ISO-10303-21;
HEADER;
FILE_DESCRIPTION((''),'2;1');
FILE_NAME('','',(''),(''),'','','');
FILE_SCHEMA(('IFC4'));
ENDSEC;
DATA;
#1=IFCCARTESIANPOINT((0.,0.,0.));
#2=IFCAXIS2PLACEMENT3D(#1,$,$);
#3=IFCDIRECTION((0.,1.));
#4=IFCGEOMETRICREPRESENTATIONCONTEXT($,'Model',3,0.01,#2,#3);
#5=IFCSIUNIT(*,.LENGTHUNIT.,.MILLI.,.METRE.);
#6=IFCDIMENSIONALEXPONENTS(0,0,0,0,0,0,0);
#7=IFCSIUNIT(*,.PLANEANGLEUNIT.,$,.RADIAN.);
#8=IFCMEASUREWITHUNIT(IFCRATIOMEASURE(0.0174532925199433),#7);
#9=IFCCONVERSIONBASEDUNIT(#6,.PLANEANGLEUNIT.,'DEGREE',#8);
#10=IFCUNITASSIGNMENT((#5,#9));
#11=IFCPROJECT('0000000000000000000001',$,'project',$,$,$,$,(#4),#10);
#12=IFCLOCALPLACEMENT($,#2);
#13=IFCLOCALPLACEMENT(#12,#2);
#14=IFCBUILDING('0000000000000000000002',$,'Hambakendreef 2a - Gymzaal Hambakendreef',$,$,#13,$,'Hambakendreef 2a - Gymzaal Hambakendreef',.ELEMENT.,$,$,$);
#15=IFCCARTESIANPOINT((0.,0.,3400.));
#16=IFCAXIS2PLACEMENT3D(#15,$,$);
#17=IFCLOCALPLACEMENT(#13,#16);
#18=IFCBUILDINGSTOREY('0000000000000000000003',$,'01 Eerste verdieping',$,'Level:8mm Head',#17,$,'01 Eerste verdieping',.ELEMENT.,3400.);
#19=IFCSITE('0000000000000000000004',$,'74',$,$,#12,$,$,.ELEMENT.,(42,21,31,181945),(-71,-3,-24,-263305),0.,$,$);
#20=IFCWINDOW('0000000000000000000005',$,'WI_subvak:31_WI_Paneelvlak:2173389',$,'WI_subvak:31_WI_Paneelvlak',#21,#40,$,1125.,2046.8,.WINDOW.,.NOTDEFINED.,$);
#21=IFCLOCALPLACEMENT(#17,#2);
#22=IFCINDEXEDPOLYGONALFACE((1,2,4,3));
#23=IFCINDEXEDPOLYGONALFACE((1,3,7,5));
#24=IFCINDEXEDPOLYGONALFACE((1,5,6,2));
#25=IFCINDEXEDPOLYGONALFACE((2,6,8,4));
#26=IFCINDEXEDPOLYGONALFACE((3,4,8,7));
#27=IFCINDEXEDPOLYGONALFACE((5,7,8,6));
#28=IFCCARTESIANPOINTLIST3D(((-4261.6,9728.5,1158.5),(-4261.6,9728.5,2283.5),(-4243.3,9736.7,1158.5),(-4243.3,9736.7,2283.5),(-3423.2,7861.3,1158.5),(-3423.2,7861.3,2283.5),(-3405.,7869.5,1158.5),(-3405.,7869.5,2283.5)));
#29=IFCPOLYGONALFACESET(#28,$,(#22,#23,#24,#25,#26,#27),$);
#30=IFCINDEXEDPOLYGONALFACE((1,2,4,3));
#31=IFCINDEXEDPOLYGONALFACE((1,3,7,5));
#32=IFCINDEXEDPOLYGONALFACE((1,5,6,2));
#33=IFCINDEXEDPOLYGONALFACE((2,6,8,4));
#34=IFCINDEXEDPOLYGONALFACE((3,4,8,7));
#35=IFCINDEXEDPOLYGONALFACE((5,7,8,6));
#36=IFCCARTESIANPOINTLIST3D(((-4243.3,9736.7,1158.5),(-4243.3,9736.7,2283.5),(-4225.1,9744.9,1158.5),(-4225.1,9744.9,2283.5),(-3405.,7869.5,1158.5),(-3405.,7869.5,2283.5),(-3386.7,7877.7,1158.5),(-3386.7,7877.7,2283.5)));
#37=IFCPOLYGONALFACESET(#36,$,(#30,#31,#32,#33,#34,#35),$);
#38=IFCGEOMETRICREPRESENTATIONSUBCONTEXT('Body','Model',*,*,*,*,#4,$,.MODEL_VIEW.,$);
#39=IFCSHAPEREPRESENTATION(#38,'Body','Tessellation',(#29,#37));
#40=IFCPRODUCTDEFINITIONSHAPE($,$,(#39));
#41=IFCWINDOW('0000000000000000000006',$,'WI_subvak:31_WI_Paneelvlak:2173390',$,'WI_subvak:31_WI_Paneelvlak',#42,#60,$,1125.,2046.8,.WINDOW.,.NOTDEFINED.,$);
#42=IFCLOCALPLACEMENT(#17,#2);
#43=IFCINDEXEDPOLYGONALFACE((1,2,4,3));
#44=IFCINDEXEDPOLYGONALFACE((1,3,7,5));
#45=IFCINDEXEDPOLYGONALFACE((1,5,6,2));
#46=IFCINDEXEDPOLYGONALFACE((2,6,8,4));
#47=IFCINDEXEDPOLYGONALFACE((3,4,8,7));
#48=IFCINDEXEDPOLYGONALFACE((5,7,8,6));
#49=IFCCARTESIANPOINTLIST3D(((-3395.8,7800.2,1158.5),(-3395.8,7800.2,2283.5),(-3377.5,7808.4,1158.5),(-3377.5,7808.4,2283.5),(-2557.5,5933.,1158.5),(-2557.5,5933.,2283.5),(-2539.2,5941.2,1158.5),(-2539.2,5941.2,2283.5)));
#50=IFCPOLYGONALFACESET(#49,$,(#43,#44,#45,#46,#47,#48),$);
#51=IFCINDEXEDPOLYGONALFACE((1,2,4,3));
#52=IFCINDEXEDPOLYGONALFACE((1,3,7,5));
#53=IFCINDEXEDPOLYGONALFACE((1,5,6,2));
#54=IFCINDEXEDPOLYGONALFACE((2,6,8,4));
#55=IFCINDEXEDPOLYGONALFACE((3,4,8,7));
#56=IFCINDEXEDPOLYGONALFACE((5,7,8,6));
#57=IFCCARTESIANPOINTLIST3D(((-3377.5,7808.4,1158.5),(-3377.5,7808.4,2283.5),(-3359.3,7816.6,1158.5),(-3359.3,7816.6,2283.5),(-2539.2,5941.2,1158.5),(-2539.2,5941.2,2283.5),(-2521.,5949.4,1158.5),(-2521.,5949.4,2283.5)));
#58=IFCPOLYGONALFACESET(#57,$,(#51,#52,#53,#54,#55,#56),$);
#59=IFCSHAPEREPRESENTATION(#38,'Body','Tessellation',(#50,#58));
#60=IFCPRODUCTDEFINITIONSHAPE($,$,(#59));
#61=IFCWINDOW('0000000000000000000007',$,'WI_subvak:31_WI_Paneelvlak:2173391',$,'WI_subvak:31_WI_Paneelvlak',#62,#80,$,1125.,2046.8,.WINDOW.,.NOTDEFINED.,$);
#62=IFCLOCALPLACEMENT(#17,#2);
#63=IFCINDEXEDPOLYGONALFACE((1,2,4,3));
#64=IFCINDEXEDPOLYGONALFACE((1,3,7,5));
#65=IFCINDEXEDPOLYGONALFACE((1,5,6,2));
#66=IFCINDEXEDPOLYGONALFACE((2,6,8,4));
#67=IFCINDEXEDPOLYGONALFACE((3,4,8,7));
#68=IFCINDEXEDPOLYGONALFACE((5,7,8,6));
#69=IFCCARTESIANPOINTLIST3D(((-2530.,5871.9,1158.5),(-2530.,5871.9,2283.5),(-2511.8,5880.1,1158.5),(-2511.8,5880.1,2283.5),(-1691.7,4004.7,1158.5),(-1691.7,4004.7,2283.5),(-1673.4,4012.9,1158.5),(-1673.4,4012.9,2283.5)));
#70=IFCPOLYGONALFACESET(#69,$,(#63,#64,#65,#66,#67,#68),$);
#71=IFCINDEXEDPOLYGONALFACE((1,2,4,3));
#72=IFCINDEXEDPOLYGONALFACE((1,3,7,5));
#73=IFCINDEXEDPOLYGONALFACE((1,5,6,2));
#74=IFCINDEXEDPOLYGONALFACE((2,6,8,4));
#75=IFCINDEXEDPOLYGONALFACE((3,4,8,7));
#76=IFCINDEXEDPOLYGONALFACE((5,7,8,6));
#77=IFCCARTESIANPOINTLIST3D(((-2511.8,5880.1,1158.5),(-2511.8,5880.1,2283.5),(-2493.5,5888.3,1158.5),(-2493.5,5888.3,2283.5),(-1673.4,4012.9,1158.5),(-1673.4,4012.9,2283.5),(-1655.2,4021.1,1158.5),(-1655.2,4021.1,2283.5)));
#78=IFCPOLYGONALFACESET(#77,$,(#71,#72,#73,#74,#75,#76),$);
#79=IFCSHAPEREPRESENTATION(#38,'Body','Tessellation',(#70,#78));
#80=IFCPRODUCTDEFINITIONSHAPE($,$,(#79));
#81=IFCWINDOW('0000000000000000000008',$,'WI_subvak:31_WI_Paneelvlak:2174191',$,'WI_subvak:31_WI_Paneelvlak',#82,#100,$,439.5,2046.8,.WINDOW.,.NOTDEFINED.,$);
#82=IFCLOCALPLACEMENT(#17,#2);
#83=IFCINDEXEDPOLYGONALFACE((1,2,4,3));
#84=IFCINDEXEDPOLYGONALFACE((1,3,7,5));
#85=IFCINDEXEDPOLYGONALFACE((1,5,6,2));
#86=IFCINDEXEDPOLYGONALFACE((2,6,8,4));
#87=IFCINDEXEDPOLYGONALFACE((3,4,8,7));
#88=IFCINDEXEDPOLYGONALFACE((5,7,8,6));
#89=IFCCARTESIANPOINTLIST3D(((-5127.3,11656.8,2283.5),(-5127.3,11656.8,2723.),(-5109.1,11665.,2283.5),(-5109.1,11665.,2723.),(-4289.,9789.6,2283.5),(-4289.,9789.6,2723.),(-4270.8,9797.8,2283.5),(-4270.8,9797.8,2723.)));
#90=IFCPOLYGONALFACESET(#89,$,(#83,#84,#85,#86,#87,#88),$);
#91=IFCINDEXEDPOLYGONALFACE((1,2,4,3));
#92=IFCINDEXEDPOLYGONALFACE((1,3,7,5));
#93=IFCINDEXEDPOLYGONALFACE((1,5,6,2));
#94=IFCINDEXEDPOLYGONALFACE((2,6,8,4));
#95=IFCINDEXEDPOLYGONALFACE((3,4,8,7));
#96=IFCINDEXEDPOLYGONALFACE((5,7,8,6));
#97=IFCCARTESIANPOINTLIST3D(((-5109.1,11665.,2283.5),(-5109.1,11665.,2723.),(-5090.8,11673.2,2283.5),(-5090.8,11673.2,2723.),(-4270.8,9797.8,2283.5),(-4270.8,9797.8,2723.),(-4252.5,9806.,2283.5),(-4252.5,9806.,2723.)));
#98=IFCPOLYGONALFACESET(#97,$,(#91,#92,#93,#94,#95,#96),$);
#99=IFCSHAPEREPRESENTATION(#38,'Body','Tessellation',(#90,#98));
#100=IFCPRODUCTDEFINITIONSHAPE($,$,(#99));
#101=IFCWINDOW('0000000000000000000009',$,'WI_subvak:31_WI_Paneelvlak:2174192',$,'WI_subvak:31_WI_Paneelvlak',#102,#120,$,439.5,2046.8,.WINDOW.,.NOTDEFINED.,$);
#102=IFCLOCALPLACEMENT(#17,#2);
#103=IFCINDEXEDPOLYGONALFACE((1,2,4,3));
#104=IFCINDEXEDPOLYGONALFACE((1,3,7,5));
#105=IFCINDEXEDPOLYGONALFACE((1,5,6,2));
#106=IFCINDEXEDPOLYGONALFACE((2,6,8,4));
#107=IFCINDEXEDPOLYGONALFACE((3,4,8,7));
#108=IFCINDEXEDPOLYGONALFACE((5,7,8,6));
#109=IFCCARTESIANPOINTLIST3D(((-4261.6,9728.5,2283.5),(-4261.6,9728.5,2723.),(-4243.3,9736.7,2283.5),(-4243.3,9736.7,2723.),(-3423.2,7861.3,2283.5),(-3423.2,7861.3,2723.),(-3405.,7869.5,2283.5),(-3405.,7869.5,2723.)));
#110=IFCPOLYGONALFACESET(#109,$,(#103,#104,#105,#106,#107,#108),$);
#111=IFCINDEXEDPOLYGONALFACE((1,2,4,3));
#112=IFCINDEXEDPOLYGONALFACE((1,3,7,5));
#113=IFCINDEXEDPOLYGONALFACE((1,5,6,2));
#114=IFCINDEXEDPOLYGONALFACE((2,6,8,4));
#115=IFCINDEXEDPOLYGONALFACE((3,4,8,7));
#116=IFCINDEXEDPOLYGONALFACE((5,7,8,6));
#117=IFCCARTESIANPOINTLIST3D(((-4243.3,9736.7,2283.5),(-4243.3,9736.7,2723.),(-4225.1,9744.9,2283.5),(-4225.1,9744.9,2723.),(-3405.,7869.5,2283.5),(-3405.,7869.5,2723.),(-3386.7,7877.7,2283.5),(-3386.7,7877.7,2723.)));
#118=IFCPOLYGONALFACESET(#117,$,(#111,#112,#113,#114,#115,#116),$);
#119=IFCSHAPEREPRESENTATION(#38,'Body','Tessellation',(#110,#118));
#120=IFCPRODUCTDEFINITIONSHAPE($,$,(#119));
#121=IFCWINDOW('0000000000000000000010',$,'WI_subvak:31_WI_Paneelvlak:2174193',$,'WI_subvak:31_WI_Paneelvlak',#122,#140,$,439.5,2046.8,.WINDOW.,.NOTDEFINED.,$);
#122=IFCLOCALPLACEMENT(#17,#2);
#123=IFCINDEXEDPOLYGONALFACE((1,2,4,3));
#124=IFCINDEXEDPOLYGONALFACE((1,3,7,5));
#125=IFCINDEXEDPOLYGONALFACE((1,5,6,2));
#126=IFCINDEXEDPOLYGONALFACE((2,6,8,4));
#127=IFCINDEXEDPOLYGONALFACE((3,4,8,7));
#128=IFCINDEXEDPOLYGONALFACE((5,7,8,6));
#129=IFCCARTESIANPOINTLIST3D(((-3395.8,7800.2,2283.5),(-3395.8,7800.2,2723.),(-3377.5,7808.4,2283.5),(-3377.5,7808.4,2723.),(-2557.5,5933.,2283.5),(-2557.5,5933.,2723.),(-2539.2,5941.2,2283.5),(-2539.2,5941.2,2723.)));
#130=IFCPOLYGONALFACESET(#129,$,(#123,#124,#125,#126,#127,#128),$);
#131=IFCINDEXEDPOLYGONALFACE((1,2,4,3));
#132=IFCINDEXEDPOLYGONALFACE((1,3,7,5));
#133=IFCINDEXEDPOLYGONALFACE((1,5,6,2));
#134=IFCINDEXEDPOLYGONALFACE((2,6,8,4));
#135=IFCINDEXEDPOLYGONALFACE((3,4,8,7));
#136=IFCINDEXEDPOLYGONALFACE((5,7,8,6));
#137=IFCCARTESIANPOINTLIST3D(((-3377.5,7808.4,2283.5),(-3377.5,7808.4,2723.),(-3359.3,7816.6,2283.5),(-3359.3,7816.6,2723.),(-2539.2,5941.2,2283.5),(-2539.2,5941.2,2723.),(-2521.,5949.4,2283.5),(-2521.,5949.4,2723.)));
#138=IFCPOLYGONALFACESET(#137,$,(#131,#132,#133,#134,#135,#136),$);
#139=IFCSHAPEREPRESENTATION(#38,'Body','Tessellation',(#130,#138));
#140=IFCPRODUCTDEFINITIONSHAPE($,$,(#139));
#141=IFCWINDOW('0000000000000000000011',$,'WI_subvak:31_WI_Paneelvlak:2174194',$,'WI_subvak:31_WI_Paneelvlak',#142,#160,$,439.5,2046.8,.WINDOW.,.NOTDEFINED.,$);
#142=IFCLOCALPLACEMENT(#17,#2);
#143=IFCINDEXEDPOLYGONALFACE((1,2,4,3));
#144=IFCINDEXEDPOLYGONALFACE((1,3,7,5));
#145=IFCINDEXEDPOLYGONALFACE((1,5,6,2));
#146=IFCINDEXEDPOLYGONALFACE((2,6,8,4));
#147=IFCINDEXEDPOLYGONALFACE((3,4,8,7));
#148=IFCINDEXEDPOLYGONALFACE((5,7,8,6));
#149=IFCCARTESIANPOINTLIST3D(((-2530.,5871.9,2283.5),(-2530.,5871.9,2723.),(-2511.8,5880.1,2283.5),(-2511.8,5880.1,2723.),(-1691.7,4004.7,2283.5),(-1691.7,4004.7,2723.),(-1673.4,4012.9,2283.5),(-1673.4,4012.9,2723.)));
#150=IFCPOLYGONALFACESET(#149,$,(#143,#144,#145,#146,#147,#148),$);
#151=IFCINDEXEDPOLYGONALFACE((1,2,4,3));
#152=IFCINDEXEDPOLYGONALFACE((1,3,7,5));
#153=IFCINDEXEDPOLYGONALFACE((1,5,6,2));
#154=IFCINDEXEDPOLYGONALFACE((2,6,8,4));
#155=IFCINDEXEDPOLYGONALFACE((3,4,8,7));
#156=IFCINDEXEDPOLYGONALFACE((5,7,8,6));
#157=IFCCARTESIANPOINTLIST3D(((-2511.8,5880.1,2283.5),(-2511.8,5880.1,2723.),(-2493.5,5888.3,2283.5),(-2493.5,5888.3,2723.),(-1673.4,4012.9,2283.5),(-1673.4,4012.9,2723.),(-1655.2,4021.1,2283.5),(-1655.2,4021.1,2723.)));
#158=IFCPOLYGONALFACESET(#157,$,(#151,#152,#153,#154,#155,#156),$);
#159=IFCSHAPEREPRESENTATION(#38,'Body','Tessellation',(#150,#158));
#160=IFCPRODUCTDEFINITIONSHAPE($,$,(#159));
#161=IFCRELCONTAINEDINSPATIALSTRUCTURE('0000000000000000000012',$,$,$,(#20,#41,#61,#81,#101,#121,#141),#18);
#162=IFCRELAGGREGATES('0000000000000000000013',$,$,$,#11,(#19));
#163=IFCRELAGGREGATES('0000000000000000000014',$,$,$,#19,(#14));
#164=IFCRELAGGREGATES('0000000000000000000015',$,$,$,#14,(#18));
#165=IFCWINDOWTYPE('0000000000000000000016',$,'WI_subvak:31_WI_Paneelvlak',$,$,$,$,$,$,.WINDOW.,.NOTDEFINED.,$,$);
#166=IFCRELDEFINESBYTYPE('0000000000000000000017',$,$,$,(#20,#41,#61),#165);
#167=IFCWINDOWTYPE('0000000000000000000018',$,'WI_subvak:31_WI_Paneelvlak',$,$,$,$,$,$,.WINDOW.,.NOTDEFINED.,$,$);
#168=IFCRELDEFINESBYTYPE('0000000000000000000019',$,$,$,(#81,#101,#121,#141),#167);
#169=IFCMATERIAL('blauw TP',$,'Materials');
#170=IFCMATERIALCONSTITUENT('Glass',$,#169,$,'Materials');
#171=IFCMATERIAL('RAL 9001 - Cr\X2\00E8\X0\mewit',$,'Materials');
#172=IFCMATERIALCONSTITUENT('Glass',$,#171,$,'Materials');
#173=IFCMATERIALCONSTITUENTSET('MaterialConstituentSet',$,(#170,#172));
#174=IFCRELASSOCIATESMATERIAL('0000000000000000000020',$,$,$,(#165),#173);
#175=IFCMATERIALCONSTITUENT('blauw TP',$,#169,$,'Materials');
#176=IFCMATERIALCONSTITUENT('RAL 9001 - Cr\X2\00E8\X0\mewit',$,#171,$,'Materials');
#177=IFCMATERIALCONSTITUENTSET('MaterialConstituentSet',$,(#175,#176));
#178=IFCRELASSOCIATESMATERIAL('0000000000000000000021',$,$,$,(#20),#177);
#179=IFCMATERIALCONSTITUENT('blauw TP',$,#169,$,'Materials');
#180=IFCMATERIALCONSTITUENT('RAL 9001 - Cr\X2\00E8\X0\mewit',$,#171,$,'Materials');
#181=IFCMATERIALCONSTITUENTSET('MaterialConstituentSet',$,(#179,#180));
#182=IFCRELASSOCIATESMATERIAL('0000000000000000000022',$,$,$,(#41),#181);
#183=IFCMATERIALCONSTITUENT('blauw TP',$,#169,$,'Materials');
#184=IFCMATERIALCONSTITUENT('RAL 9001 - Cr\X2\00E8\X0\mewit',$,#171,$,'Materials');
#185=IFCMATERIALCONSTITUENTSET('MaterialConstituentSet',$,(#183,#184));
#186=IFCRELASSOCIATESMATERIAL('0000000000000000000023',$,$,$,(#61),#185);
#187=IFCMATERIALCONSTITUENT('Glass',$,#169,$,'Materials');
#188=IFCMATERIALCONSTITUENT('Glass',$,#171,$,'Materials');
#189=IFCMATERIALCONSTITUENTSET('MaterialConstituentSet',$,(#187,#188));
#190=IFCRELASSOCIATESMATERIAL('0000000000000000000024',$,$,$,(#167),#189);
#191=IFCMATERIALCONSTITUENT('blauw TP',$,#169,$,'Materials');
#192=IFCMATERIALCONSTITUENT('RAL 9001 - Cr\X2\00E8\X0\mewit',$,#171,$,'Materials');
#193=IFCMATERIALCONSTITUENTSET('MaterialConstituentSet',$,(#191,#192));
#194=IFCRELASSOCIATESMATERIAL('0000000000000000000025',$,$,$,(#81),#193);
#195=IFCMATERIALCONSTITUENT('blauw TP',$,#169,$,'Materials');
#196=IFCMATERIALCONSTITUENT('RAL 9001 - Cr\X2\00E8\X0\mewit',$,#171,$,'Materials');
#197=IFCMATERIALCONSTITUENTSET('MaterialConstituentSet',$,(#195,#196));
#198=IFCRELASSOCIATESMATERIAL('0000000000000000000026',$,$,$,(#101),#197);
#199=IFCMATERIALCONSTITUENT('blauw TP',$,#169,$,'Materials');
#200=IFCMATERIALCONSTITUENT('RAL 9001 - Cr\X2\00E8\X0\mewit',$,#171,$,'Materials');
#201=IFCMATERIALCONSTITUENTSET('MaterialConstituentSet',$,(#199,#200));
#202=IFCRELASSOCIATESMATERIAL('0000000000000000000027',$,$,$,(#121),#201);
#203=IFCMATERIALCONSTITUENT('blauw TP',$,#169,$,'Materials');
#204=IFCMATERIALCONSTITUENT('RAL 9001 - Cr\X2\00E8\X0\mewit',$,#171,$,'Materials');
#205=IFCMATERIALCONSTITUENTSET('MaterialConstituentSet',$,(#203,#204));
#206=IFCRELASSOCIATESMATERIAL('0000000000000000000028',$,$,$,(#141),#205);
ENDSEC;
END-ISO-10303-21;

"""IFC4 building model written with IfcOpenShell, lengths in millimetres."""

from ifc_helpers import new_model, entity, si_unit, converted_unit, direction, frame, origin, place, context, subcontext, project, spatial, indexed_curve, outline, extrude, source, transform, mapped, material, constituent, constituent_set, type_object, type_shapes, element, save


model = new_model("IFC4")

# Units and contexts
model_context = context("Model", 3, precision=0.01, world=origin(), true_north=direction((0.0, 1.0)))
body_context = subcontext(model_context, "Body", "Model", "MODEL_VIEW")
ifc_project = project(units=[si_unit("LENGTHUNIT", "METRE", prefix="MILLI"), converted_unit("PLANEANGLEUNIT", "DEGREE", entity("IfcRatioMeasure", 0.0174532925199433), si_unit("PLANEANGLEUNIT", "RADIAN"), dimensions=[0, 0, 0, 0, 0, 0, 0])], contexts=[model_context])

# Site, building, storey
site_placement = place(None, origin())
site = spatial("IfcSite", under=ifc_project, at=site_placement, Name="74", CompositionType="ELEMENT", RefLatitude=(42, 21, 31, 181945), RefLongitude=(-71, -3, -24, -263305), RefElevation=0.0)
building_placement = place(site_placement, origin())
building = spatial("IfcBuilding", under=site, at=building_placement, Name="Hambakendreef 2a - Gymzaal Hambakendreef", LongName="Hambakendreef 2a - Gymzaal Hambakendreef", CompositionType="ELEMENT")
storey_placement = place(building_placement, frame((0.0, 0.0, 3400.0)))
storey = spatial("IfcBuildingStorey", under=building, at=storey_placement, Name="01 Eerste verdieping", ObjectType="Level:8mm Head", LongName="01 Eerste verdieping", CompositionType="ELEMENT", Elevation=3400.0)

# Windows
ifc_material_1 = material(Name="blauw TP", Category="Materials")
ifc_material_2 = material(Name="RAL 9001 - Crèmewit", Category="Materials")
ifc_constituent_1 = constituent(ifc_material_1, Name="Glass", Category="Materials")
ifc_constituent_2 = constituent(ifc_material_2, Name="Glass", Category="Materials")
ifc_constituent_set_1 = constituent_set(constituents=[ifc_constituent_1, ifc_constituent_2], Name="MaterialConstituentSet")
window_type_1 = type_object("IfcWindowType", Name="WI_subvak:31_WI_Paneelvlak", PartitioningType="NOTDEFINED", PredefinedType="WINDOW", material=ifc_constituent_set_1)
shared_shape_1 = source(origin(), body_context, "Body", "SweptSolid", [
    extrude(outline(indexed_curve([(-1023.4, -10.0), (1023.4, -10.0), (1023.4, 10.0), (-1023.4, 10.0), (-1023.4, -10.0)], self_intersect=False)), frame((0.0, -10.0, 0.0)), (0.0, 0.0, 1.0), 1125.0),
    extrude(outline(indexed_curve([(-1023.4, -10.0), (1023.4, -10.0), (1023.4, 10.0), (-1023.4, 10.0), (-1023.4, -10.0)], self_intersect=False)), frame((0.0, 10.0, 0.0)), (0.0, 0.0, 1.0), 1125.0),
])
type_shapes(window_type_1, [shared_shape_1])
ifc_constituent_3 = constituent(ifc_material_1, Name="blauw TP", Category="Materials")
ifc_constituent_4 = constituent(ifc_material_2, Name="RAL 9001 - Crèmewit", Category="Materials")
ifc_constituent_set_2 = constituent_set(constituents=[ifc_constituent_3, ifc_constituent_4], Name="MaterialConstituentSet")
window_1_placement = place(storey_placement, frame((-3824.2, 8803.1, 1158.5), z_axis=(0.0, 0.0, 1.0), x_axis=(0.40959, -0.91227, 0.0)))
element("IfcWindow", 1, at=window_1_placement, inside=storey, type_object=window_type_1, material=ifc_constituent_set_2, Name="WI_subvak:31_WI_Paneelvlak:2173389", ObjectType="WI_subvak:31_WI_Paneelvlak", OverallHeight=1125.0, OverallWidth=2046.8, PartitioningType="NOTDEFINED", PredefinedType="WINDOW", context=body_context, shape_type="MappedRepresentation", body=[
    mapped(shared_shape_1, transform((0.0, 0.0, 0.0), scale=1.0)),
])
ifc_constituent_5 = constituent(ifc_material_1, Name="blauw TP", Category="Materials")
ifc_constituent_6 = constituent(ifc_material_2, Name="RAL 9001 - Crèmewit", Category="Materials")
ifc_constituent_set_3 = constituent_set(constituents=[ifc_constituent_5, ifc_constituent_6], Name="MaterialConstituentSet")
window_2_placement = place(storey_placement, frame((-2958.4, 6874.8, 1158.5), z_axis=(0.0, 0.0, 1.0), x_axis=(0.40959, -0.91227, 0.0)))
element("IfcWindow", 2, at=window_2_placement, inside=storey, type_object=window_type_1, material=ifc_constituent_set_3, Name="WI_subvak:31_WI_Paneelvlak:2173390", ObjectType="WI_subvak:31_WI_Paneelvlak", OverallHeight=1125.0, OverallWidth=2046.8, PartitioningType="NOTDEFINED", PredefinedType="WINDOW", context=body_context, shape_type="MappedRepresentation", body=[
    mapped(shared_shape_1, transform((0.0, 0.0, 0.0), scale=1.0)),
])
ifc_constituent_7 = constituent(ifc_material_1, Name="blauw TP", Category="Materials")
ifc_constituent_8 = constituent(ifc_material_2, Name="RAL 9001 - Crèmewit", Category="Materials")
ifc_constituent_set_4 = constituent_set(constituents=[ifc_constituent_7, ifc_constituent_8], Name="MaterialConstituentSet")
window_3_placement = place(storey_placement, frame((-2092.6, 4946.5, 1158.5), z_axis=(0.0, 0.0, 1.0), x_axis=(0.40959, -0.91227, 0.0)))
element("IfcWindow", 3, at=window_3_placement, inside=storey, type_object=window_type_1, material=ifc_constituent_set_4, Name="WI_subvak:31_WI_Paneelvlak:2173391", ObjectType="WI_subvak:31_WI_Paneelvlak", OverallHeight=1125.0, OverallWidth=2046.8, PartitioningType="NOTDEFINED", PredefinedType="WINDOW", context=body_context, shape_type="MappedRepresentation", body=[
    mapped(shared_shape_1, transform((0.0, 0.0, 0.0), scale=1.0)),
])
ifc_constituent_9 = constituent(ifc_material_1, Name="blauw TP", Category="Materials")
ifc_constituent_10 = constituent(ifc_material_2, Name="RAL 9001 - Crèmewit", Category="Materials")
ifc_constituent_set_5 = constituent_set(constituents=[ifc_constituent_9, ifc_constituent_10], Name="MaterialConstituentSet")
ifc_constituent_11 = constituent(ifc_material_1, Name="Glass", Category="Materials")
ifc_constituent_12 = constituent(ifc_material_2, Name="Glass", Category="Materials")
ifc_constituent_set_6 = constituent_set(constituents=[ifc_constituent_11, ifc_constituent_12], Name="MaterialConstituentSet")
window_type_2 = type_object("IfcWindowType", Name="WI_subvak:31_WI_Paneelvlak", PartitioningType="NOTDEFINED", PredefinedType="WINDOW", material=ifc_constituent_set_6)
shared_shape_2 = source(origin(), body_context, "Body", "SweptSolid", [
    extrude(outline(indexed_curve([(-1023.4, -10.0), (1023.4, -10.0), (1023.4, 10.0), (-1023.4, 10.0), (-1023.4, -10.0)], self_intersect=False)), frame((0.0, -10.0, 0.0)), (0.0, 0.0, 1.0), 439.5),
    extrude(outline(indexed_curve([(-1023.4, -10.0), (1023.4, -10.0), (1023.4, 10.0), (-1023.4, 10.0), (-1023.4, -10.0)], self_intersect=False)), frame((0.0, 10.0, 0.0)), (0.0, 0.0, 1.0), 439.5),
])
type_shapes(window_type_2, [shared_shape_2])
window_4_placement = place(storey_placement, frame((-4689.9, 10731.4, 2283.5), z_axis=(0.0, 0.0, 1.0), x_axis=(0.40959, -0.91227, 0.0)))
element("IfcWindow", 4, at=window_4_placement, inside=storey, type_object=window_type_2, material=ifc_constituent_set_5, Name="WI_subvak:31_WI_Paneelvlak:2174191", ObjectType="WI_subvak:31_WI_Paneelvlak", OverallHeight=439.5, OverallWidth=2046.8, PartitioningType="NOTDEFINED", PredefinedType="WINDOW", context=body_context, shape_type="MappedRepresentation", body=[
    mapped(shared_shape_2, transform((0.0, 0.0, 0.0), scale=1.0)),
])
ifc_constituent_13 = constituent(ifc_material_1, Name="blauw TP", Category="Materials")
ifc_constituent_14 = constituent(ifc_material_2, Name="RAL 9001 - Crèmewit", Category="Materials")
ifc_constituent_set_7 = constituent_set(constituents=[ifc_constituent_13, ifc_constituent_14], Name="MaterialConstituentSet")
window_5_placement = place(storey_placement, frame((-3824.2, 8803.1, 2283.5), z_axis=(0.0, 0.0, 1.0), x_axis=(0.40959, -0.91227, 0.0)))
element("IfcWindow", 5, at=window_5_placement, inside=storey, type_object=window_type_2, material=ifc_constituent_set_7, Name="WI_subvak:31_WI_Paneelvlak:2174192", ObjectType="WI_subvak:31_WI_Paneelvlak", OverallHeight=439.5, OverallWidth=2046.8, PartitioningType="NOTDEFINED", PredefinedType="WINDOW", context=body_context, shape_type="MappedRepresentation", body=[
    mapped(shared_shape_2, transform((0.0, 0.0, 0.0), scale=1.0)),
])
ifc_constituent_15 = constituent(ifc_material_1, Name="blauw TP", Category="Materials")
ifc_constituent_16 = constituent(ifc_material_2, Name="RAL 9001 - Crèmewit", Category="Materials")
ifc_constituent_set_8 = constituent_set(constituents=[ifc_constituent_15, ifc_constituent_16], Name="MaterialConstituentSet")
window_6_placement = place(storey_placement, frame((-2958.4, 6874.8, 2283.5), z_axis=(0.0, 0.0, 1.0), x_axis=(0.40959, -0.91227, 0.0)))
element("IfcWindow", 6, at=window_6_placement, inside=storey, type_object=window_type_2, material=ifc_constituent_set_8, Name="WI_subvak:31_WI_Paneelvlak:2174193", ObjectType="WI_subvak:31_WI_Paneelvlak", OverallHeight=439.5, OverallWidth=2046.8, PartitioningType="NOTDEFINED", PredefinedType="WINDOW", context=body_context, shape_type="MappedRepresentation", body=[
    mapped(shared_shape_2, transform((0.0, 0.0, 0.0), scale=1.0)),
])
ifc_constituent_17 = constituent(ifc_material_1, Name="blauw TP", Category="Materials")
ifc_constituent_18 = constituent(ifc_material_2, Name="RAL 9001 - Crèmewit", Category="Materials")
ifc_constituent_set_9 = constituent_set(constituents=[ifc_constituent_17, ifc_constituent_18], Name="MaterialConstituentSet")
window_7_placement = place(storey_placement, frame((-2092.6, 4946.5, 2283.5), z_axis=(0.0, 0.0, 1.0), x_axis=(0.40959, -0.91227, 0.0)))
element("IfcWindow", 7, at=window_7_placement, inside=storey, type_object=window_type_2, material=ifc_constituent_set_9, Name="WI_subvak:31_WI_Paneelvlak:2174194", ObjectType="WI_subvak:31_WI_Paneelvlak", OverallHeight=439.5, OverallWidth=2046.8, PartitioningType="NOTDEFINED", PredefinedType="WINDOW", context=body_context, shape_type="MappedRepresentation", body=[
    mapped(shared_shape_2, transform((0.0, 0.0, 0.0), scale=1.0)),
])

save(model, "model.ifc")
